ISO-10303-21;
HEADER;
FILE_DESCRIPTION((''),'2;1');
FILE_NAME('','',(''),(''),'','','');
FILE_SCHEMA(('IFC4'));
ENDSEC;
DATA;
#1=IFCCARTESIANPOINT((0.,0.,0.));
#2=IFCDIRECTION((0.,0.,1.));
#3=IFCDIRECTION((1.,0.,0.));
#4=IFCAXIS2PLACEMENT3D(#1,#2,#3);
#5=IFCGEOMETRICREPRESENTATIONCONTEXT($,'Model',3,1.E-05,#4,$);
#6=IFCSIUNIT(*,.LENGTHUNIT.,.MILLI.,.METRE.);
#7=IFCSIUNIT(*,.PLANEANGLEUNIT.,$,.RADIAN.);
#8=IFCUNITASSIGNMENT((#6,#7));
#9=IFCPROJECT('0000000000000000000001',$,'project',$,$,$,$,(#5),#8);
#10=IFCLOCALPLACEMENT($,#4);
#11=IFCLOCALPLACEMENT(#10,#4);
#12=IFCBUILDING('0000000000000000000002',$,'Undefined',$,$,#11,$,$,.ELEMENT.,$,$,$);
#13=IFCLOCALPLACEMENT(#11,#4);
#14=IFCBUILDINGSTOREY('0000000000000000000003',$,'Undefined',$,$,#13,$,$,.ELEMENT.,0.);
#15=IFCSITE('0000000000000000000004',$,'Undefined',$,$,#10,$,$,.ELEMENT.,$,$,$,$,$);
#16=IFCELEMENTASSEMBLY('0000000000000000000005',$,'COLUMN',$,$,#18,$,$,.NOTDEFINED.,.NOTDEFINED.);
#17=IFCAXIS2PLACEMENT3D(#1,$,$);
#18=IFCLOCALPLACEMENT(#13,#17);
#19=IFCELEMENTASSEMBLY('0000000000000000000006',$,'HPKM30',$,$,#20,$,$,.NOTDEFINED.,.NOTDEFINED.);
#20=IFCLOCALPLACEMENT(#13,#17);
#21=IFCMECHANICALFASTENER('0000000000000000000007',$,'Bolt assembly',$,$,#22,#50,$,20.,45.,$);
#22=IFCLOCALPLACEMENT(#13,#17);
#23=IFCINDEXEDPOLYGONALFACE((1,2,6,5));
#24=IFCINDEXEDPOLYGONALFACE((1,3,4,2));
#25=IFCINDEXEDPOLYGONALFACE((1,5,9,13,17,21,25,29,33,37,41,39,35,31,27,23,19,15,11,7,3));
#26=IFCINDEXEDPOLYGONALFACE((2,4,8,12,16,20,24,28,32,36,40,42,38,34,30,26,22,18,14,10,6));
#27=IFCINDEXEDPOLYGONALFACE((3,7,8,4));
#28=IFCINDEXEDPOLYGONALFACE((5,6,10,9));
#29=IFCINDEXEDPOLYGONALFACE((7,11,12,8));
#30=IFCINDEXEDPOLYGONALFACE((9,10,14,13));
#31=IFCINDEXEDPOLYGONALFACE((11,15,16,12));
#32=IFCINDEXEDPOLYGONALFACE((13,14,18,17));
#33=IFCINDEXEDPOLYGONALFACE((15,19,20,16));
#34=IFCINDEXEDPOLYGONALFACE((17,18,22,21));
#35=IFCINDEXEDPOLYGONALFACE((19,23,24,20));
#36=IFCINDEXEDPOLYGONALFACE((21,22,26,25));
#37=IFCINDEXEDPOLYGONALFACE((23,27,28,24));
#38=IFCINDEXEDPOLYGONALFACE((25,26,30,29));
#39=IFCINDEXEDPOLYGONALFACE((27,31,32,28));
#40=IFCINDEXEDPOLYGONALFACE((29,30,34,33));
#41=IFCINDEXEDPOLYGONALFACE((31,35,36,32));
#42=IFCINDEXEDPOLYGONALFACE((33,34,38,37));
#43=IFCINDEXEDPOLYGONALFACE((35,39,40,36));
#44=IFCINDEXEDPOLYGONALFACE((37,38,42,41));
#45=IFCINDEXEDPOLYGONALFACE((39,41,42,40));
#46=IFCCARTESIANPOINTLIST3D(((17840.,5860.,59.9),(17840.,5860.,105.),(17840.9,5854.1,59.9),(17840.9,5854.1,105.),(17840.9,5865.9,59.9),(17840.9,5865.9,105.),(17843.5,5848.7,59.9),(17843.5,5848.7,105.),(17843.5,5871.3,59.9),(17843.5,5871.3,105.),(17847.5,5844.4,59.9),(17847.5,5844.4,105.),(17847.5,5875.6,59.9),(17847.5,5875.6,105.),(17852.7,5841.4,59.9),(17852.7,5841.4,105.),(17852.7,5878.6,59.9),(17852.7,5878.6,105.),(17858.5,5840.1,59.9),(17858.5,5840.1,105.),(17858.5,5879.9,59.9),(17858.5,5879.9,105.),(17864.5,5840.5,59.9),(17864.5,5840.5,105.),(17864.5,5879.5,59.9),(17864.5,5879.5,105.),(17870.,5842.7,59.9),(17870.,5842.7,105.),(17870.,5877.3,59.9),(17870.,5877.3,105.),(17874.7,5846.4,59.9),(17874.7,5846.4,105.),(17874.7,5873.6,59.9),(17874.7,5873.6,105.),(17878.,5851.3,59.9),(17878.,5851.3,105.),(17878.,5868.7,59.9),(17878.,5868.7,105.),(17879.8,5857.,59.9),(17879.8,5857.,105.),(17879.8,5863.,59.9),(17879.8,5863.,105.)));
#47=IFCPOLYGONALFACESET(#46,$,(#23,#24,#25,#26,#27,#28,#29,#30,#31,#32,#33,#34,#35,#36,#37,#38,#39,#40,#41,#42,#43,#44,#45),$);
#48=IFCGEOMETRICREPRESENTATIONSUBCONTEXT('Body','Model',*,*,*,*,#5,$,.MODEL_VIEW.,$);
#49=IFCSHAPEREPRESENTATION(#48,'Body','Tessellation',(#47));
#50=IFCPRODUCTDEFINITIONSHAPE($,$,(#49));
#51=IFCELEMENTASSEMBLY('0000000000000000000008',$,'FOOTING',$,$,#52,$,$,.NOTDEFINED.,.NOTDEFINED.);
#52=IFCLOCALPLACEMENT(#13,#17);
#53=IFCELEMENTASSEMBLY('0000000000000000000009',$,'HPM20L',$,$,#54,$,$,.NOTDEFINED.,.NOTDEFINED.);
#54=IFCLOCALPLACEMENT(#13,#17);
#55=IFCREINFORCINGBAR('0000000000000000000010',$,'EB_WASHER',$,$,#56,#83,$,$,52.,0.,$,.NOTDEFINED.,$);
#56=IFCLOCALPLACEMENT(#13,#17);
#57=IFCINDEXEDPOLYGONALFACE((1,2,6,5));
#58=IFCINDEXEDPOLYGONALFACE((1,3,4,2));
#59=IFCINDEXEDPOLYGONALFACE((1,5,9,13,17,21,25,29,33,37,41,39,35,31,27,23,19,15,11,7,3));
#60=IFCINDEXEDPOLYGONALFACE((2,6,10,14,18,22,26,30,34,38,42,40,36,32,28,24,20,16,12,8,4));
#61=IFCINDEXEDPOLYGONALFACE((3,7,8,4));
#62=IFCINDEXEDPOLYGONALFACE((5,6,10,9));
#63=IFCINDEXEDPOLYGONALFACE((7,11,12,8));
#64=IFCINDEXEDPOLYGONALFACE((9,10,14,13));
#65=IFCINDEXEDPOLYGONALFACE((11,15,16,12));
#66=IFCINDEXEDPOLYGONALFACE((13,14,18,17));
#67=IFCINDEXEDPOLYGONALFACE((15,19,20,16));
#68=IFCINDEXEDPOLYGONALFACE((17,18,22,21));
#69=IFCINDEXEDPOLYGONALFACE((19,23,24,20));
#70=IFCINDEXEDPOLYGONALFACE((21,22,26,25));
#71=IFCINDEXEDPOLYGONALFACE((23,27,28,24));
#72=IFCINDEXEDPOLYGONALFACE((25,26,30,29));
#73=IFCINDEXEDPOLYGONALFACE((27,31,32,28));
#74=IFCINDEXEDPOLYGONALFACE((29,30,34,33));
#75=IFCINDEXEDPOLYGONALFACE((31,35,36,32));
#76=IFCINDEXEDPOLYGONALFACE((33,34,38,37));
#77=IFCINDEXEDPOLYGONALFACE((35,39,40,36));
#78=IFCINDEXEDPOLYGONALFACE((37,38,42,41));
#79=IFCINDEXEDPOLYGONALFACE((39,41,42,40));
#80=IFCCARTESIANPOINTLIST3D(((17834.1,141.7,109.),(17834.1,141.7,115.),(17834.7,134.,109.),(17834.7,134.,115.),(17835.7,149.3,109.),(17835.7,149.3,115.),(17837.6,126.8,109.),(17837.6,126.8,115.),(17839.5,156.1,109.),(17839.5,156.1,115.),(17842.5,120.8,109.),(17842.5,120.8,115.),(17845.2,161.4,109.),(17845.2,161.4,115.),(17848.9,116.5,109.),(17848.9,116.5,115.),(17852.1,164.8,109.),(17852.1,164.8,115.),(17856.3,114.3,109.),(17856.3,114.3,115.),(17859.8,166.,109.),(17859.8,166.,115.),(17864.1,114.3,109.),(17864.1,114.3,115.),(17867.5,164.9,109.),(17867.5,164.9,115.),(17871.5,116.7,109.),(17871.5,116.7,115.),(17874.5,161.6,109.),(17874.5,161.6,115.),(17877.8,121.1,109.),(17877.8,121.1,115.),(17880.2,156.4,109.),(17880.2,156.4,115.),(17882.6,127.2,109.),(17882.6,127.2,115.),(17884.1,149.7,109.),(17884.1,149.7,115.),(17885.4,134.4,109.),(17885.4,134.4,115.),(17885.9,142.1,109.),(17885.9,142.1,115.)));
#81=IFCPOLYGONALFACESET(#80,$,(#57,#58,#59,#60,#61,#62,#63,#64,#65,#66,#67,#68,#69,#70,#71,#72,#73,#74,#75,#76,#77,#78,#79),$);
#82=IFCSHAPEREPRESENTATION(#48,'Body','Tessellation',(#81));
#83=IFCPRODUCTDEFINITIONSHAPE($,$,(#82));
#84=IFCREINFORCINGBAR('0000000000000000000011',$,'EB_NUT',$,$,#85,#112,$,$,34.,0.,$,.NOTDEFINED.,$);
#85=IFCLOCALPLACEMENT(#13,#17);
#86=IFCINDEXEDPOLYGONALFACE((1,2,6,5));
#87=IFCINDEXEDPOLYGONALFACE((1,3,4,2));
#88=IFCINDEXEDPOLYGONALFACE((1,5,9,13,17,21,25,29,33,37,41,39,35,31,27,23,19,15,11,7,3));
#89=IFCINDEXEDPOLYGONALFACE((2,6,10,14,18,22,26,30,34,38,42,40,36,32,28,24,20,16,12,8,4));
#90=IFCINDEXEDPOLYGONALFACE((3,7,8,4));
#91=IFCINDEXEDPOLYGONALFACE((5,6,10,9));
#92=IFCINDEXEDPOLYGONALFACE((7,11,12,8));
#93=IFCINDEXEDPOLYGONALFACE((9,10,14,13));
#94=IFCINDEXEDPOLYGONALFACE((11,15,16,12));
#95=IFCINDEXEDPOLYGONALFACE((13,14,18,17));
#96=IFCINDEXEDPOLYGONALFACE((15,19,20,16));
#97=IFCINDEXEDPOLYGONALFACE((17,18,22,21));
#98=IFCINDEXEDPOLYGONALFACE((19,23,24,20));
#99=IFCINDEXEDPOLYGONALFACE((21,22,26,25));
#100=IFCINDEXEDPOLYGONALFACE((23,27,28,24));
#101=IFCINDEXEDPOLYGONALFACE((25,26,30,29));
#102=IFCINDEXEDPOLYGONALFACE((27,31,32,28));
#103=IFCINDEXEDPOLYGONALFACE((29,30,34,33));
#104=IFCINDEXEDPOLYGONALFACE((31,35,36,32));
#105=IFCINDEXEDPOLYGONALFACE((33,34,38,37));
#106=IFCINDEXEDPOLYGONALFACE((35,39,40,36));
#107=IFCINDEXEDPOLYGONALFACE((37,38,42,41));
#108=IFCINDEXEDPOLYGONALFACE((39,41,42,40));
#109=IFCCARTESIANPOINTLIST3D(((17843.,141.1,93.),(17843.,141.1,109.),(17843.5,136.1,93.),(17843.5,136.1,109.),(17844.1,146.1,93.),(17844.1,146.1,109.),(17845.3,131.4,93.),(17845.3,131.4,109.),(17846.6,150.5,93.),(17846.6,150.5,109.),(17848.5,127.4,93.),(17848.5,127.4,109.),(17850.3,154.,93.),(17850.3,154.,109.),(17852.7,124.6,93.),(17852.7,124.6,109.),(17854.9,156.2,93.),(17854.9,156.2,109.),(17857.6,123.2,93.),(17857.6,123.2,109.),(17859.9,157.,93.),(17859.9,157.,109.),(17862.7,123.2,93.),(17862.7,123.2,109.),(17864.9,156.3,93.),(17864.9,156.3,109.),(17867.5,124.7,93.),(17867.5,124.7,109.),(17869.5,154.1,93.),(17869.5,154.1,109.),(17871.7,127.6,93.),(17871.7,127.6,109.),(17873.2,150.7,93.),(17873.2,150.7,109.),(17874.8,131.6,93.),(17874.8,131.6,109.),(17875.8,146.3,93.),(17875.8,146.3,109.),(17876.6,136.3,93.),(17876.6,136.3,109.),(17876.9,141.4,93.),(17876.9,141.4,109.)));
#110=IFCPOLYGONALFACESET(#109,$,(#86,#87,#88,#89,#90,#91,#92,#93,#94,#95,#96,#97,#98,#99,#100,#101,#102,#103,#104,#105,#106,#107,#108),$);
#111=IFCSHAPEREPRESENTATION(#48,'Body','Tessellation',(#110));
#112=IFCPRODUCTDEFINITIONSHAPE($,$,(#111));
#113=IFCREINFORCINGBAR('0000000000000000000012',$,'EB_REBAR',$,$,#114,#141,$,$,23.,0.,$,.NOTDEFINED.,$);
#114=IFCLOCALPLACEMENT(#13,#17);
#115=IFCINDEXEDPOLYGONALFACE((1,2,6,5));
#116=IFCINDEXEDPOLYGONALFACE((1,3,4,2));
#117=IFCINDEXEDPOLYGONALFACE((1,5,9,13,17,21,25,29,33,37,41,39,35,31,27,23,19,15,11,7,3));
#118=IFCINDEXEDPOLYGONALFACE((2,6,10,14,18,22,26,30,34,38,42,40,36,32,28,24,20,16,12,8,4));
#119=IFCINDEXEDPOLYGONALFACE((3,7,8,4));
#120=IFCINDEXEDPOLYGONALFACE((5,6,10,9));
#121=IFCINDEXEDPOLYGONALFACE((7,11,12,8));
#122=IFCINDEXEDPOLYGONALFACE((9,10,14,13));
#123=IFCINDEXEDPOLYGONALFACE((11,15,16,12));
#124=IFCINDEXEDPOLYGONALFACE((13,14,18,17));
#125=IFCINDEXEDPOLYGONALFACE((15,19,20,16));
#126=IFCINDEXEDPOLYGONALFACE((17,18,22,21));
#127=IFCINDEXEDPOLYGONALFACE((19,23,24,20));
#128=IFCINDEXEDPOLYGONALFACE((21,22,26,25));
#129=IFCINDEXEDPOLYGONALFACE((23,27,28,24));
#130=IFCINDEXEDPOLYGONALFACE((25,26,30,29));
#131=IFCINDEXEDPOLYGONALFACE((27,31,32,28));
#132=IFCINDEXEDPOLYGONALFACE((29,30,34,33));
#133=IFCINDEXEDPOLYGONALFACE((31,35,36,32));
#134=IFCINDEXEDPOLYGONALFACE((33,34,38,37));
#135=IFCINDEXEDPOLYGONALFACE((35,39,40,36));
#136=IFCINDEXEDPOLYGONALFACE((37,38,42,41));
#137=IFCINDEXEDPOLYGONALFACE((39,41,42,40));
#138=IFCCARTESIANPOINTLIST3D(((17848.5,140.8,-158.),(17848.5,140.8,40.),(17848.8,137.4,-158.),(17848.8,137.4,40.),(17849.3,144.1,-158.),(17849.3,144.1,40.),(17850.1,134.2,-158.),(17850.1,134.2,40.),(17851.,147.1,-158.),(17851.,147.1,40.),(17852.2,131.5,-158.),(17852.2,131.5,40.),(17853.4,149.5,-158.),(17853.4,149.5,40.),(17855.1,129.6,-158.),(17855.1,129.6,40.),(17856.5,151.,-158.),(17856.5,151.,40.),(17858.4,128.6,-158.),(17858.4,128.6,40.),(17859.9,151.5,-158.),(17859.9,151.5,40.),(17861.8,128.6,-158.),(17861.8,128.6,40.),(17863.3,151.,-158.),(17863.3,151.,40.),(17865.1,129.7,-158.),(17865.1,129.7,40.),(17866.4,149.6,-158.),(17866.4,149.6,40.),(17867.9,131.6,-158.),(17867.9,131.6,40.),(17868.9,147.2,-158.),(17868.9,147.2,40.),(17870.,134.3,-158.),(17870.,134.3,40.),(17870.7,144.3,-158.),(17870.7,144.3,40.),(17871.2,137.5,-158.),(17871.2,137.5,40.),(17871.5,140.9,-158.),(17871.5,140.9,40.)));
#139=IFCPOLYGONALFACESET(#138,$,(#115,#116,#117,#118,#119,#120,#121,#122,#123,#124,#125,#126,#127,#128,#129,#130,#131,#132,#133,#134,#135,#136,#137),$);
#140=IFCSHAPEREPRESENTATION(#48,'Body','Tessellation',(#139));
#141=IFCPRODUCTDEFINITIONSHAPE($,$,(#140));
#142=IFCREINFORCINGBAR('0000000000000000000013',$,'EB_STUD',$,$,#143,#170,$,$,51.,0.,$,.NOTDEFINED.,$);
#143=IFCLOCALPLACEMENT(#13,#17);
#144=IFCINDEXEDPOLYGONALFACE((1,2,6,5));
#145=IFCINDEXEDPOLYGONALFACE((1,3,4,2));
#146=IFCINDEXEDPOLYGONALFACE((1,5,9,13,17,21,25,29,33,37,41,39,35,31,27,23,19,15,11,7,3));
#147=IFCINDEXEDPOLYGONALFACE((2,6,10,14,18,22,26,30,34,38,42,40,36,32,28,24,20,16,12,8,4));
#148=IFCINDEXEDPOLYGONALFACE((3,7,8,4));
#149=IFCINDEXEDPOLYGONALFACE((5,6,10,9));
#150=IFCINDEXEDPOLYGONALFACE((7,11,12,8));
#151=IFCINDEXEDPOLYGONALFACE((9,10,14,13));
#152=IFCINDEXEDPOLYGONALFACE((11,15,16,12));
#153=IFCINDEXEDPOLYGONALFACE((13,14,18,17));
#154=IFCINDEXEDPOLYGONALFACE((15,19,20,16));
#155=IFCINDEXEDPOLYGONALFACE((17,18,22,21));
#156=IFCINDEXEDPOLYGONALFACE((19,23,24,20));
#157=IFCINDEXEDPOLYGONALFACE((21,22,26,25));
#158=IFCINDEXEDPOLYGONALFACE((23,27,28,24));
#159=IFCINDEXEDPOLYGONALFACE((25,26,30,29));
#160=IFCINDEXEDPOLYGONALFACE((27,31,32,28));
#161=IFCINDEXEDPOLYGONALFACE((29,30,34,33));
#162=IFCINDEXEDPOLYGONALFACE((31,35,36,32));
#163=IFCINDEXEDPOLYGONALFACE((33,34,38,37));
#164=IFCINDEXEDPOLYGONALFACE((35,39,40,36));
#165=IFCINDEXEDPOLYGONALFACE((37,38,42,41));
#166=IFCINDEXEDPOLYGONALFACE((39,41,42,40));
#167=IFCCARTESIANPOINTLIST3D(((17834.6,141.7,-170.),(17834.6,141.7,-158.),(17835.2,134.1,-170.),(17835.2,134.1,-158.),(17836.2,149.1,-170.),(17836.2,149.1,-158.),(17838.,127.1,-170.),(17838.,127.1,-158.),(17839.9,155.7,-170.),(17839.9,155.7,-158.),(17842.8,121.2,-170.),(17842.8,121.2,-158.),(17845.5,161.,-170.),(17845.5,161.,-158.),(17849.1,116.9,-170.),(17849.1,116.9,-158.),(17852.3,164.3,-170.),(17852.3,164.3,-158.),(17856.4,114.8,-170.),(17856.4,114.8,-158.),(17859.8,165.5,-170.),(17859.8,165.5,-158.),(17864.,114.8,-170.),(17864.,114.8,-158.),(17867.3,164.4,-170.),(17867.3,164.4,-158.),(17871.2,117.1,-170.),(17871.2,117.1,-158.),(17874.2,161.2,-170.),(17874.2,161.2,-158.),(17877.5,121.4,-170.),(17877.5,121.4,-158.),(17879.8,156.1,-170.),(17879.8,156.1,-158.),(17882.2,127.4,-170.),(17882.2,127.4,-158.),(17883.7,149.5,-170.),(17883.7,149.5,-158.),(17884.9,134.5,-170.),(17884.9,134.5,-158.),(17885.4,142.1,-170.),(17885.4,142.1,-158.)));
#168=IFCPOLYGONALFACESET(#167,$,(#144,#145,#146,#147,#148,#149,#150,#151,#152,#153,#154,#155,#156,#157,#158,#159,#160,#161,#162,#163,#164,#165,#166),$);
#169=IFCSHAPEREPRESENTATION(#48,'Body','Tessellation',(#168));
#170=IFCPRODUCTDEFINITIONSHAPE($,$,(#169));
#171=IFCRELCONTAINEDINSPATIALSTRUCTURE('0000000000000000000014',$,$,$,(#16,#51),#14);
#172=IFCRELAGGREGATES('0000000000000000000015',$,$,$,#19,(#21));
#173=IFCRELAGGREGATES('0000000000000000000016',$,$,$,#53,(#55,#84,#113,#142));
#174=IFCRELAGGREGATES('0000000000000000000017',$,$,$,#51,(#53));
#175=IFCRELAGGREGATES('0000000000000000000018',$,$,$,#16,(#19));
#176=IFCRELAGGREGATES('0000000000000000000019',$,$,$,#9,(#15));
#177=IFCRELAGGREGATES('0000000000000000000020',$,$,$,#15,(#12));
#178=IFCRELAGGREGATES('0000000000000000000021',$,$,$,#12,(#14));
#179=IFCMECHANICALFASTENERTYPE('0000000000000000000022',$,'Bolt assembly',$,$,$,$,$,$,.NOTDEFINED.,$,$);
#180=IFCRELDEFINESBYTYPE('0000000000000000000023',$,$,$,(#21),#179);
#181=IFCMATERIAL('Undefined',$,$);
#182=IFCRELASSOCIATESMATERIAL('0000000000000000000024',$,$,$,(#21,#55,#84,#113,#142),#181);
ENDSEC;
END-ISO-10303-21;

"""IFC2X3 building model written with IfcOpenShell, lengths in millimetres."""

from ifc_helpers import new_model, entity, si_unit, frame, origin_with_axes, origin_2d_with_axis, place, context, subcontext, project, spatial, circle, extrude, source, transform, mapped, material, type_object, element, aggregate, save


model = new_model("IFC2X3")

# Units and contexts
model_context = context("Model", 3, precision=1e-05, world=origin_with_axes())
body_context = subcontext(model_context, "Body", "Model", "MODEL_VIEW")
ifc_project = project(units=[si_unit("LENGTHUNIT", "METRE", prefix="MILLI"), si_unit("PLANEANGLEUNIT", "RADIAN")], contexts=[model_context])

# Site, building, storey
site_placement = place(None, origin_with_axes())
site = spatial("IfcSite", under=ifc_project, at=site_placement, Name="Undefined", CompositionType="ELEMENT")
building_placement = place(site_placement, origin_with_axes())
building = spatial("IfcBuilding", under=site, at=building_placement, Name="Undefined", CompositionType="ELEMENT")
storey_placement = place(building_placement, origin_with_axes())
storey = spatial("IfcBuildingStorey", under=building, at=storey_placement, Name="Undefined", CompositionType="ELEMENT", Elevation=0.0)

# Shared definitions
ifc_material_1 = material(Name="Undefined")

# Shared definitions
mechanical_fastener_type = type_object("IfcMechanicalFastenerType", Name="Bolt assembly")

# Shared definitions
shared_shape_1 = source(origin_with_axes(), body_context, "Body", "SweptSolid", [
    extrude(circle(Radius=20.0, at=origin_2d_with_axis()), frame((0.0, -45.0, 0.0), z_axis=(0.0, 1.0, 0.0), x_axis=(1.0, 0.0, 0.0)), (0.0, 0.0, 1.0), 45.1),
])

# Element assemblies, mechanical fastener
assembly_1_placement = place(storey_placement, origin_with_axes())
assembly_1 = element("IfcElementAssembly", 1, at=assembly_1_placement, inside=storey, Name="COLUMN", AssemblyPlace="NOTDEFINED", PredefinedType="NOTDEFINED")
assembly_2_placement = place(assembly_1_placement, origin_with_axes())
assembly_2 = element("IfcElementAssembly", 2, at=assembly_2_placement, Name="HPKM30", AssemblyPlace="NOTDEFINED", PredefinedType="NOTDEFINED")
mechanical_fastener_1_placement = place(assembly_2_placement, frame((17860.0, 5860.0, 60.0), z_axis=(0.0, -1.0, 0.0), x_axis=(-1.0, 0.0, 0.0)))
mechanical_fastener_1 = element("IfcMechanicalFastener", 3, at=mechanical_fastener_1_placement, type_object=mechanical_fastener_type, material=ifc_material_1, Name="Bolt assembly", NominalDiameter=20.0, NominalLength=45.0, context=body_context, shape_type="MappedRepresentation", body=[
    mapped(shared_shape_1, transform((0.0, 0.0, 0.0))),
])
aggregate(assembly_2, [mechanical_fastener_1])

# Element assemblies, reinforcing bars
assembly_3_placement = place(storey_placement, origin_with_axes())
assembly_3 = element("IfcElementAssembly", 4, at=assembly_3_placement, inside=storey, Name="FOOTING", AssemblyPlace="NOTDEFINED", PredefinedType="NOTDEFINED")
assembly_4_placement = place(assembly_3_placement, origin_with_axes())
assembly_4 = element("IfcElementAssembly", 5, at=assembly_4_placement, Name="HPM20L", AssemblyPlace="NOTDEFINED", PredefinedType="NOTDEFINED")
shared_shape_2 = source(origin_with_axes(), body_context, "Body", "AdvancedSweptSolid", [
    entity("IfcSweptDiskSolid", entity("IfcTrimmedCurve", entity("IfcLine", entity("IfcCartesianPoint", [0.0, 0.0, 0.0]), entity("IfcVector", entity("IfcDirection", [1.0, 0.0, 0.0]), 1.0)), [entity("IfcParameterValue", 0.0)], [entity("IfcParameterValue", 6.0)], True, "PARAMETER"), 26.0, None, 0.0, 6.0),
])
reinforcing_bar_1_placement = place(assembly_4_placement, frame((17860.0, 140.0, 115.0), z_axis=(-0.007839, 0.999969, 0.0), x_axis=(0.0, 0.0, -1.0)))
reinforcing_bar_1 = element("IfcReinforcingBar", 6, at=reinforcing_bar_1_placement, material=ifc_material_1, Name="EB_WASHER", BarRole="NOTDEFINED", CrossSectionArea=0.0, NominalDiameter=52.0, context=body_context, shape_type="MappedRepresentation", body=[
    mapped(shared_shape_2, transform((0.0, 0.0, 0.0))),
])
shared_shape_3 = source(origin_with_axes(), body_context, "Body", "AdvancedSweptSolid", [
    entity("IfcSweptDiskSolid", entity("IfcTrimmedCurve", entity("IfcLine", entity("IfcCartesianPoint", [0.0, 0.0, 0.0]), entity("IfcVector", entity("IfcDirection", [1.0, 0.0, 0.0]), 1.0)), [entity("IfcParameterValue", 0.0)], [entity("IfcParameterValue", 16.0)], True, "PARAMETER"), 17.0, None, 0.0, 16.0),
])
reinforcing_bar_2_placement = place(assembly_4_placement, frame((17860.0, 140.0, 109.0), z_axis=(-0.007839, 0.999969, 0.0), x_axis=(0.0, 0.0, -1.0)))
reinforcing_bar_2 = element("IfcReinforcingBar", 7, at=reinforcing_bar_2_placement, material=ifc_material_1, Name="EB_NUT", BarRole="NOTDEFINED", CrossSectionArea=0.0, NominalDiameter=34.0, context=body_context, shape_type="MappedRepresentation", body=[
    mapped(shared_shape_3, transform((0.0, 0.0, 0.0))),
])
shared_shape_4 = source(origin_with_axes(), body_context, "Body", "AdvancedSweptSolid", [
    entity("IfcSweptDiskSolid", entity("IfcTrimmedCurve", entity("IfcLine", entity("IfcCartesianPoint", [0.0, 0.0, 0.0]), entity("IfcVector", entity("IfcDirection", [1.0, 0.0, 0.0]), 1.0)), [entity("IfcParameterValue", 0.0)], [entity("IfcParameterValue", 198.0)], True, "PARAMETER"), 11.5, None, 0.0, 198.0),
])
reinforcing_bar_3_placement = place(assembly_4_placement, frame((17860.0, 140.0, 40.0), z_axis=(-0.007839, 0.999969, 0.0), x_axis=(0.0, 0.0, -1.0)))
reinforcing_bar_3 = element("IfcReinforcingBar", 8, at=reinforcing_bar_3_placement, material=ifc_material_1, Name="EB_REBAR", BarRole="NOTDEFINED", CrossSectionArea=0.0, NominalDiameter=23.0, context=body_context, shape_type="MappedRepresentation", body=[
    mapped(shared_shape_4, transform((0.0, 0.0, 0.0))),
])
shared_shape_5 = source(origin_with_axes(), body_context, "Body", "AdvancedSweptSolid", [
    entity("IfcSweptDiskSolid", entity("IfcTrimmedCurve", entity("IfcLine", entity("IfcCartesianPoint", [0.0, 0.0, 0.0]), entity("IfcVector", entity("IfcDirection", [1.0, 0.0, 0.0]), 1.0)), [entity("IfcParameterValue", 0.0)], [entity("IfcParameterValue", 12.0)], True, "PARAMETER"), 25.5, None, 0.0, 12.0),
])
reinforcing_bar_4_placement = place(assembly_4_placement, frame((17860.0, 140.0, -158.0), z_axis=(-0.007839, 0.999969, 0.0), x_axis=(0.0, 0.0, -1.0)))
reinforcing_bar_4 = element("IfcReinforcingBar", 9, at=reinforcing_bar_4_placement, material=ifc_material_1, Name="EB_STUD", BarRole="NOTDEFINED", CrossSectionArea=0.0, NominalDiameter=51.0, context=body_context, shape_type="MappedRepresentation", body=[
    mapped(shared_shape_5, transform((0.0, 0.0, 0.0))),
])
aggregate(assembly_4, [reinforcing_bar_1, reinforcing_bar_2, reinforcing_bar_3, reinforcing_bar_4])
aggregate(assembly_3, [assembly_4])

aggregate(assembly_1, [assembly_2])

save(model, "model.ifc")
